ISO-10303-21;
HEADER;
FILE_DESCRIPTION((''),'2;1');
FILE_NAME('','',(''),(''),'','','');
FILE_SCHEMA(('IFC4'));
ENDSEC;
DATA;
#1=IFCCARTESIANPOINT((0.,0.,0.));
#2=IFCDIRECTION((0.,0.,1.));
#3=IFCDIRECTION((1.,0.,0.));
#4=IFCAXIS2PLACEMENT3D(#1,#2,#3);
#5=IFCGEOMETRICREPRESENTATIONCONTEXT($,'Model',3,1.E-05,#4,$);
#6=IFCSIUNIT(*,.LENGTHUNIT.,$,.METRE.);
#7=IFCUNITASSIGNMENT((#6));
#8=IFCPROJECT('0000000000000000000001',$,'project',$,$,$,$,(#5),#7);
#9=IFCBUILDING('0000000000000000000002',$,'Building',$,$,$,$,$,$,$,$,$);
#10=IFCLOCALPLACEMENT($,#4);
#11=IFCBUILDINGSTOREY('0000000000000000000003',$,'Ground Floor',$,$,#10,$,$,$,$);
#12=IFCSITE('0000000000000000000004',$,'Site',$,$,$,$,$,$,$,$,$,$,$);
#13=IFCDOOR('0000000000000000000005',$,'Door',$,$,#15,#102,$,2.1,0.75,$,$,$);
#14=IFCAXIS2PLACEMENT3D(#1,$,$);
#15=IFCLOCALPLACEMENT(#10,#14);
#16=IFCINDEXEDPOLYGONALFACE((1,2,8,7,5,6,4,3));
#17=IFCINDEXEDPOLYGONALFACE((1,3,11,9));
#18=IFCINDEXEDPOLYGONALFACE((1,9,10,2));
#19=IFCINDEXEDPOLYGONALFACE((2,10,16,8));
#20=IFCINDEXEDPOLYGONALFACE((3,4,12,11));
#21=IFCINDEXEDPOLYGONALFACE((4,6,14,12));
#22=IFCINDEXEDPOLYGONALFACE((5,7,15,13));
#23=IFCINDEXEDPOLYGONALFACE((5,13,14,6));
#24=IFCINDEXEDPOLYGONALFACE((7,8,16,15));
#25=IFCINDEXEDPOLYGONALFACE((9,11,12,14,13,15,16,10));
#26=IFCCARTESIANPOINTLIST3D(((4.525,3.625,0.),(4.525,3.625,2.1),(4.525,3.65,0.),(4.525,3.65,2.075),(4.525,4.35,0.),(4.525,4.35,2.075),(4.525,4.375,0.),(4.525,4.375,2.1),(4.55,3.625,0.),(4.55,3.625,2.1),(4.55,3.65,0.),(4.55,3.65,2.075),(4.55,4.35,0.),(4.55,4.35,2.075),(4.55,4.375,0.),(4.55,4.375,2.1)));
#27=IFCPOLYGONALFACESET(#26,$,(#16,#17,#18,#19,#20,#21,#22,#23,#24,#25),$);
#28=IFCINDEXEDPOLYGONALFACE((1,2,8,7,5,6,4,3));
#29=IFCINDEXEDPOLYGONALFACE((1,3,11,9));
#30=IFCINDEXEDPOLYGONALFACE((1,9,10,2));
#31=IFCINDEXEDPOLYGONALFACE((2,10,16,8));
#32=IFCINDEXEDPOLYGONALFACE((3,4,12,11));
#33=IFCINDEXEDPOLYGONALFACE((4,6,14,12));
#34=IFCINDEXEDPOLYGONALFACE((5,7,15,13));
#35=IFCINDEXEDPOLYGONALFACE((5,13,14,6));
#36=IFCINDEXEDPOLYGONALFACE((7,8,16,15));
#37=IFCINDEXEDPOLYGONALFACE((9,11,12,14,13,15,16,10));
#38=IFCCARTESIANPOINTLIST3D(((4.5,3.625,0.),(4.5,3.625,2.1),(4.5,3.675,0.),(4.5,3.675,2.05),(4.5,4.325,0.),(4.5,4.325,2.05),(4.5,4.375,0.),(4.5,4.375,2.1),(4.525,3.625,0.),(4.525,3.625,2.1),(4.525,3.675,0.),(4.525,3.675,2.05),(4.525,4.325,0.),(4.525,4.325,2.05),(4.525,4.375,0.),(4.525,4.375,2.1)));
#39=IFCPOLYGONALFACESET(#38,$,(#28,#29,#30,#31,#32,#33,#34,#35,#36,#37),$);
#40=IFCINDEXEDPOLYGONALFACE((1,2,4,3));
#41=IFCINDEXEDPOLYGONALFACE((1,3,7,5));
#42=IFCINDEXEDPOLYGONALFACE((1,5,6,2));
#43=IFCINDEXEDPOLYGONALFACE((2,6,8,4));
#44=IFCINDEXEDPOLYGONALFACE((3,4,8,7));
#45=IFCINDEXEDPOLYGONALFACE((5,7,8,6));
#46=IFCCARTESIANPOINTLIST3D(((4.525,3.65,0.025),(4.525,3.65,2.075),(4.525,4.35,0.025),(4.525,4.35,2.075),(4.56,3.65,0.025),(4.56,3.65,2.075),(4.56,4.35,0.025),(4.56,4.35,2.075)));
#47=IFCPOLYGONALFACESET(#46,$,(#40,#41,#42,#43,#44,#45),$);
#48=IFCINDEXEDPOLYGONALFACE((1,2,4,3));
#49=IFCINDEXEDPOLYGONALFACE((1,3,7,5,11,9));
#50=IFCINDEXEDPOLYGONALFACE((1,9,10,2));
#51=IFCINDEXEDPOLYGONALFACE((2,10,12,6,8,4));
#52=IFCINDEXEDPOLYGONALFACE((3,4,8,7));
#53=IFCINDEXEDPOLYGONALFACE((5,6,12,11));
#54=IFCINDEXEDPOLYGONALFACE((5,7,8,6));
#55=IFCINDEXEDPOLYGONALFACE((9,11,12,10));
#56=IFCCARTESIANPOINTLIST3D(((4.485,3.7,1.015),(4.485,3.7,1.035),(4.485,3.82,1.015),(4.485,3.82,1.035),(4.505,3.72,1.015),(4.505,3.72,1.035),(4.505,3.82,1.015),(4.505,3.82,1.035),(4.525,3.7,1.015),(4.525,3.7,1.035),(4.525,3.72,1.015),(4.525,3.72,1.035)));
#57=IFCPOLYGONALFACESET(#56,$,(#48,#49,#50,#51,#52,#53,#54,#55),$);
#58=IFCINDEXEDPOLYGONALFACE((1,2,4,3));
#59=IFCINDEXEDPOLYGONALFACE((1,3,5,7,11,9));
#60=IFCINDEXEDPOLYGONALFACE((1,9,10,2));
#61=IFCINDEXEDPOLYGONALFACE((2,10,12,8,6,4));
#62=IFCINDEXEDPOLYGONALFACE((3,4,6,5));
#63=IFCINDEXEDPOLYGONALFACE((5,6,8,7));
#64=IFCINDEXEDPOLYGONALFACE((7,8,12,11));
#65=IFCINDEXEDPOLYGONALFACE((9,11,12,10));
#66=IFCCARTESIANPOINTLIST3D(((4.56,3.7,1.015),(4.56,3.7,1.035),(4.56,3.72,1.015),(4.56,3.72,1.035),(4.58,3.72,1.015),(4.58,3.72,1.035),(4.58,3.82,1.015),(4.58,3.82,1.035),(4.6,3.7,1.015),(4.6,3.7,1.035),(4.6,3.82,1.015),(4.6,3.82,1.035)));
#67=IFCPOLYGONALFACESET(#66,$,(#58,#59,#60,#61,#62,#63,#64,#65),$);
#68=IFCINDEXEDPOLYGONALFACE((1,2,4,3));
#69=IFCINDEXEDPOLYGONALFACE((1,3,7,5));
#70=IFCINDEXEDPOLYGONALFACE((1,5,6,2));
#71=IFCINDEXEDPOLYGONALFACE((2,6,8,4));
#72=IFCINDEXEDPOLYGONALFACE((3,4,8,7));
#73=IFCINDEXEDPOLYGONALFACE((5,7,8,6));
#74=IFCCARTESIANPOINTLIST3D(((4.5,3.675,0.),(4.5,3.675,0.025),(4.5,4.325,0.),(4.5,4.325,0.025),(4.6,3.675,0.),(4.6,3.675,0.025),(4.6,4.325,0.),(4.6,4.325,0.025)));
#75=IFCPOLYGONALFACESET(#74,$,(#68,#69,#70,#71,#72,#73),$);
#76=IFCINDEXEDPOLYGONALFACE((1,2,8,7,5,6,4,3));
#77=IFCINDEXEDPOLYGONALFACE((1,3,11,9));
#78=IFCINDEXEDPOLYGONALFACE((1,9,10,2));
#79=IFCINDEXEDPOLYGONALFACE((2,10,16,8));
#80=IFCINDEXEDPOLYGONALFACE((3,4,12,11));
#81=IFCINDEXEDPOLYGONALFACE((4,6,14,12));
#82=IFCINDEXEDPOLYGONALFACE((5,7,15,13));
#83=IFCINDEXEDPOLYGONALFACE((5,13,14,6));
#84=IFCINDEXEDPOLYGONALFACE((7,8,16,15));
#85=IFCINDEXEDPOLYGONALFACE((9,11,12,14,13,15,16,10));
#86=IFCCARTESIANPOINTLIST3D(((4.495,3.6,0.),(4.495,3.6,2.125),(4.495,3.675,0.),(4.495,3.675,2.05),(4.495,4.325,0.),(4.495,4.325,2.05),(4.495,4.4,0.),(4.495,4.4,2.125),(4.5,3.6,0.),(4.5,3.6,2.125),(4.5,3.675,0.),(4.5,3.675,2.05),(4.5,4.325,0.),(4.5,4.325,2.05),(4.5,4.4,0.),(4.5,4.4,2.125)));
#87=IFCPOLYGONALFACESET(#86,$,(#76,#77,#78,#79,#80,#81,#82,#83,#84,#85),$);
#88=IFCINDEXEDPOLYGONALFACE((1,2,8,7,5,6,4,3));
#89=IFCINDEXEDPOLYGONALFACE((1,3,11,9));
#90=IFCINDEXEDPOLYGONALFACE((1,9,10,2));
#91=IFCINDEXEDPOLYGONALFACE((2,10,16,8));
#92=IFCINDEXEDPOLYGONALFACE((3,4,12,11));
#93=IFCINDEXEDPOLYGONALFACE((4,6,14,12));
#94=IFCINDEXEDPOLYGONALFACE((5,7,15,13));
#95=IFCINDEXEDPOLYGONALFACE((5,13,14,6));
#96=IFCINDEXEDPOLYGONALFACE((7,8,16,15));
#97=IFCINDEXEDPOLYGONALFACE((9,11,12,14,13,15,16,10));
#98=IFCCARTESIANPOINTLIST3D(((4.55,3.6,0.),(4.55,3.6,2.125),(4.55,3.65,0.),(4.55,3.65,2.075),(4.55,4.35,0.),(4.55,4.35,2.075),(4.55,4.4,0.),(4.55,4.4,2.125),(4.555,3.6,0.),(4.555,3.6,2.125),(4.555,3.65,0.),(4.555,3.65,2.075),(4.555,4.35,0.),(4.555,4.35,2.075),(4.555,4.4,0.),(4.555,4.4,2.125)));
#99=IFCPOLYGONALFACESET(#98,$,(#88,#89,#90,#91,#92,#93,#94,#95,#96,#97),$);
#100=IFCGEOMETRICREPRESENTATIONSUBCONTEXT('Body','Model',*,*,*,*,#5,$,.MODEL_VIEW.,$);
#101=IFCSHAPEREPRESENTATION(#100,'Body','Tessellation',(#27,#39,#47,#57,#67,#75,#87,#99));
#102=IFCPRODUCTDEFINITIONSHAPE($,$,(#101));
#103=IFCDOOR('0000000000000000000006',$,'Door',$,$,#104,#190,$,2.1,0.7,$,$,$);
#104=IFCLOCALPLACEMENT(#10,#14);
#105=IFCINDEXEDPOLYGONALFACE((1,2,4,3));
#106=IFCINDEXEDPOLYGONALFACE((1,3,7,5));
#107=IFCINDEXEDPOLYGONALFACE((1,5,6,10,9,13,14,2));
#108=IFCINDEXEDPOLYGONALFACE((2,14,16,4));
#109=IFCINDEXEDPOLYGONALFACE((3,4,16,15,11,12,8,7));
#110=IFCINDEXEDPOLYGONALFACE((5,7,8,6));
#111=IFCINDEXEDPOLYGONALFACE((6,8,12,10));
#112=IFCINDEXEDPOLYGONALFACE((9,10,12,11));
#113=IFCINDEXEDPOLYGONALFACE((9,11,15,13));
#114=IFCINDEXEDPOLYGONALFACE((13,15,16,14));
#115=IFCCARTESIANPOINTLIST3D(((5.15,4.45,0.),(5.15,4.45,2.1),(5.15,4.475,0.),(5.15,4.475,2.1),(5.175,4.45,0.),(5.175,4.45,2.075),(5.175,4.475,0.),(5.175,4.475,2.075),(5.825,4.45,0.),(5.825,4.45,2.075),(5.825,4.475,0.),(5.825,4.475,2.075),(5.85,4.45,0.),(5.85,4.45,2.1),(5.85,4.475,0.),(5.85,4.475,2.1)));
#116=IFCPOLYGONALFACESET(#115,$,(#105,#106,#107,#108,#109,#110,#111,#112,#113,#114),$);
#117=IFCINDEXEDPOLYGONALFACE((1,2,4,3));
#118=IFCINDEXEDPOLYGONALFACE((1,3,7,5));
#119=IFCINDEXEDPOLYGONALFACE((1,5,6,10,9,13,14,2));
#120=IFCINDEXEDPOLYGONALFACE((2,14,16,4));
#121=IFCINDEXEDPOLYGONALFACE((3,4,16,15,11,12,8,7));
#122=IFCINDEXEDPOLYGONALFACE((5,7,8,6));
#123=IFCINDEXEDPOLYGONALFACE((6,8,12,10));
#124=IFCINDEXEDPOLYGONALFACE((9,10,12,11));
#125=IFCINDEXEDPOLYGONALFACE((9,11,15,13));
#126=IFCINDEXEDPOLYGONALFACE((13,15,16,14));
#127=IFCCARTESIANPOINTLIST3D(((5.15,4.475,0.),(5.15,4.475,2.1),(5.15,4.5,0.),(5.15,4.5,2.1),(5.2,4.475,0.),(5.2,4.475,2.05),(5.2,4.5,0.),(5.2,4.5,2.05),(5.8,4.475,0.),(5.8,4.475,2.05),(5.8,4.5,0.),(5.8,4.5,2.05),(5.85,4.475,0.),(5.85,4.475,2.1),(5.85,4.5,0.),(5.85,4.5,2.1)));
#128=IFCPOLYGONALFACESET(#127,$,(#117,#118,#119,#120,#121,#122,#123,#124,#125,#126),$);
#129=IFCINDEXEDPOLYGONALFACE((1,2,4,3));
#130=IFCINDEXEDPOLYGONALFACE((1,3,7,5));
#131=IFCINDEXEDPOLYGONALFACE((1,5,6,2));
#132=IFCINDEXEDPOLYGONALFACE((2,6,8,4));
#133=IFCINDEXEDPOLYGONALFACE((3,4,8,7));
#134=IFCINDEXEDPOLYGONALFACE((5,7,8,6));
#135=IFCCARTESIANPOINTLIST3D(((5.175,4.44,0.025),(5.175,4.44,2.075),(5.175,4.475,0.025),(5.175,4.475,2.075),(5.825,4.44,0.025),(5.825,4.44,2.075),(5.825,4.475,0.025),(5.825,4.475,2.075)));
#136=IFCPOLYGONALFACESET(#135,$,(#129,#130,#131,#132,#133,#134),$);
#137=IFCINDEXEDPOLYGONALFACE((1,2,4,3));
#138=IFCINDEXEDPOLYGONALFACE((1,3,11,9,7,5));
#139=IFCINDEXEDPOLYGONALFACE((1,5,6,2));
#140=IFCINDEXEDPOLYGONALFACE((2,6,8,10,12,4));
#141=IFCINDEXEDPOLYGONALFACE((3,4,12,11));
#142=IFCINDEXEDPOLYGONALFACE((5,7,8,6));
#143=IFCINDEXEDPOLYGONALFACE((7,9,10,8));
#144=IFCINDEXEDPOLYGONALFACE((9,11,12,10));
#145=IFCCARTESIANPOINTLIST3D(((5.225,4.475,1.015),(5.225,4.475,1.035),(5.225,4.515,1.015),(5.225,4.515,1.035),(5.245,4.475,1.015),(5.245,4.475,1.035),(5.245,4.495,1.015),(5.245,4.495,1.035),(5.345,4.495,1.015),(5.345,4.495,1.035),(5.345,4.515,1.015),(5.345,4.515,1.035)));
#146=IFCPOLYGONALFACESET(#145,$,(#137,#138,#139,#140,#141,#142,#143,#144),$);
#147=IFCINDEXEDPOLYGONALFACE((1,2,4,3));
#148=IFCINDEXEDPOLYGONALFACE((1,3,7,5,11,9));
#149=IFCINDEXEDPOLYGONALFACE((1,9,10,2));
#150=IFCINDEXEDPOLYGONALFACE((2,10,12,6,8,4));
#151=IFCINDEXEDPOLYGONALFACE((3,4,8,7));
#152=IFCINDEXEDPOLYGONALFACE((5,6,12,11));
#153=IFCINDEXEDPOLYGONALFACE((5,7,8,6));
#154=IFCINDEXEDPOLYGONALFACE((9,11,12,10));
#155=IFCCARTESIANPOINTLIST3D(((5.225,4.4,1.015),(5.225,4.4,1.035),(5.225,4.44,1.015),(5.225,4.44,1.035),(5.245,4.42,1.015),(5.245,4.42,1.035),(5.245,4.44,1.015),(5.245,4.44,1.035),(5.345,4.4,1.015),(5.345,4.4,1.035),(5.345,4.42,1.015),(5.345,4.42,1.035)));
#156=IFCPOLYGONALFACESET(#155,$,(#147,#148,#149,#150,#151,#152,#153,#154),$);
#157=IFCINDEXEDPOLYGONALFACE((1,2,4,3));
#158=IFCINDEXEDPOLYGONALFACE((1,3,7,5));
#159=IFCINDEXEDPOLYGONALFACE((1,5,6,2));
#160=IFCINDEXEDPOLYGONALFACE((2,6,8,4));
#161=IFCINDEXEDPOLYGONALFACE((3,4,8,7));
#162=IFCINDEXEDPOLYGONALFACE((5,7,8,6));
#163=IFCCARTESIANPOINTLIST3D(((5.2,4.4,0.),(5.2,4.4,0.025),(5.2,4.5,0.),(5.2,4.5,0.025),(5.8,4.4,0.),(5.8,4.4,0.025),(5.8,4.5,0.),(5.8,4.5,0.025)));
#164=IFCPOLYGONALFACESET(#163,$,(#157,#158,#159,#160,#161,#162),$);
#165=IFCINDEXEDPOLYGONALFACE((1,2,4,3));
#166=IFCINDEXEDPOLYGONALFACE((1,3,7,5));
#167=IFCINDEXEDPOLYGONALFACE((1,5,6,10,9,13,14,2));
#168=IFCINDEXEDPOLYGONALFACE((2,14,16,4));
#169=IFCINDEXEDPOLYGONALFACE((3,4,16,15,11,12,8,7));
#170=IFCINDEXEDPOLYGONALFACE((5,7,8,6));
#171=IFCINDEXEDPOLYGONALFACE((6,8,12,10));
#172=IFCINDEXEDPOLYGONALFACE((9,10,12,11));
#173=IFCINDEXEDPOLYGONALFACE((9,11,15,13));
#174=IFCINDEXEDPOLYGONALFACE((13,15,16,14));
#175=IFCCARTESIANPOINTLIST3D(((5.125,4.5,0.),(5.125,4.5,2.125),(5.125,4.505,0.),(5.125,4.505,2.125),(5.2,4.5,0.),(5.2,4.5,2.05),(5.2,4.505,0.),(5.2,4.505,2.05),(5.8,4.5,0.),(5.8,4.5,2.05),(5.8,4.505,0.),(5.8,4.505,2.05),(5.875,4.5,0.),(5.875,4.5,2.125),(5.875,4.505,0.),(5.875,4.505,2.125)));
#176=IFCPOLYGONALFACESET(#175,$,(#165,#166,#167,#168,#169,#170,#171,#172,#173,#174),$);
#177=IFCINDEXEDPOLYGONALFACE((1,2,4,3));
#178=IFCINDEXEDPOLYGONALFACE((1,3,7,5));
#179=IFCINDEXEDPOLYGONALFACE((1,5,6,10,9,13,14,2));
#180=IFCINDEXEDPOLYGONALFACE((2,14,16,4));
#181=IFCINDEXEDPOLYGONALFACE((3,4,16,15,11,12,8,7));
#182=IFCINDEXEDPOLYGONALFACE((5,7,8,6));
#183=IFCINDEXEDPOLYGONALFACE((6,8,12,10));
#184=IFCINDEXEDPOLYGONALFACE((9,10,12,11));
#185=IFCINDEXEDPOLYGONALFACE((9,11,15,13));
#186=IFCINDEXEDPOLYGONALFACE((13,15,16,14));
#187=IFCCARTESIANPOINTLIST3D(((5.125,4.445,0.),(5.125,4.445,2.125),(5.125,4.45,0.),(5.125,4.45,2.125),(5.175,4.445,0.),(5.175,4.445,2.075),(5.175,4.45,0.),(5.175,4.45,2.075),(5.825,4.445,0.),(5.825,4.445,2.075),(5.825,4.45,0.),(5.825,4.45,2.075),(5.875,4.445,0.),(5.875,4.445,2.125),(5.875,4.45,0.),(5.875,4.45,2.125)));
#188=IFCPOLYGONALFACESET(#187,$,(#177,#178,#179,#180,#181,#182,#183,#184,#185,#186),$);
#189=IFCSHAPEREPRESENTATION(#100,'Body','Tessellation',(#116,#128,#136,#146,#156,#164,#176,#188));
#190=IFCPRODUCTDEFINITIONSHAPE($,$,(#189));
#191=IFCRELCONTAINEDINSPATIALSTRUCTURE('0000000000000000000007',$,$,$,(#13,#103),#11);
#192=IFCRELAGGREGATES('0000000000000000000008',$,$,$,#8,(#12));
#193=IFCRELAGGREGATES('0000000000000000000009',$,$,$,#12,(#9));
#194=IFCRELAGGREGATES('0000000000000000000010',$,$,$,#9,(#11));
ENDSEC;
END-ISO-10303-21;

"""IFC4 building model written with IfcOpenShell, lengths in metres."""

from ifc_helpers import new_model, si_unit, frame, origin_with_axes, place, context, subcontext, project, spatial, line, indexed_curve, outline, extrude, element, save


model = new_model("IFC4")

# Units and contexts
model_context = context("Model", 3, precision=1e-05, world=origin_with_axes())
body_context = subcontext(model_context, "Body", "Model", "MODEL_VIEW")
ifc_project = project(units=[si_unit("LENGTHUNIT", "METRE")], contexts=[model_context])

# Site, building, storey
site = spatial("IfcSite", under=ifc_project, Name="Site")
building = spatial("IfcBuilding", under=site, Name="Building")
storey_placement = place(None, origin_with_axes())
storey = spatial("IfcBuildingStorey", under=building, at=storey_placement, Name="Ground Floor")

# Doors
door_1_placement = place(storey_placement, frame((4.5, 4.375, 0.0), z_axis=(0.0, 0.0, 1.0), x_axis=(0.0, -1.0, 0.0)))
element("IfcDoor", 1, at=door_1_placement, inside=storey, Name="Door", OverallHeight=2.1, OverallWidth=0.75, context=body_context, shape_type="SweptSolid", body=[
    extrude(outline(indexed_curve([(0.0, 0.0), (0.0, 2.1), (0.75, 2.1), (0.75, 0.0), (0.725, 0.0), (0.725, 2.075), (0.025, 2.075), (0.025, 0.0)], segments=[line(1, 2, 3, 4, 5, 6, 7, 8, 1)])), frame((0.0, 0.025, 0.0), z_axis=(0.0, -1.0, 0.0), x_axis=(1.0, 0.0, 0.0)), (0.0, 0.0, -1.0), 0.025),
    extrude(outline(indexed_curve([(0.0, 0.0), (0.0, 2.1), (0.75, 2.1), (0.75, 0.0), (0.7, 0.0), (0.7, 2.05), (0.05, 2.05), (0.05, 0.0)], segments=[line(1, 2, 3, 4, 5, 6, 7, 8, 1)])), frame((0.0, 0.0, 0.0), z_axis=(0.0, -1.0, 0.0), x_axis=(1.0, 0.0, 0.0)), (0.0, 0.0, -1.0), 0.025),
    extrude(outline(indexed_curve([(0.0, 0.0), (0.7, 0.0), (0.7, 0.035), (0.0, 0.035)], segments=[line(1, 2, 3, 4, 1)])), frame((0.025, 0.025, 0.025), z_axis=(0.0, 0.0, 1.0), x_axis=(1.0, 0.0, 0.0)), (0.0, 0.0, 1.0), 2.05),
    extrude(outline(indexed_curve([(0.0, 0.0), (0.0, -0.04), (-0.12, -0.04), (-0.12, -0.02), (-0.02, -0.02), (-0.02, 0.0)], segments=[line(1, 2, 3, 4, 5, 6, 1)])), frame((0.675, 0.025, 1.015), z_axis=(0.0, 0.0, 1.0), x_axis=(1.0, 0.0, 0.0)), (0.0, 0.0, 1.0), 0.02),
    extrude(outline(indexed_curve([(0.0, 0.0), (0.0, 0.04), (-0.12, 0.04), (-0.12, 0.02), (-0.02, 0.02), (-0.02, 0.0)], segments=[line(1, 2, 3, 4, 5, 6, 1)])), frame((0.675, 0.06, 1.015), z_axis=(0.0, 0.0, 1.0), x_axis=(1.0, 0.0, 0.0)), (0.0, 0.0, 1.0), 0.02),
    extrude(outline(indexed_curve([(0.0, 0.0), (0.65, 0.0), (0.65, 0.1), (0.0, 0.1)], segments=[line(1, 2, 3, 4, 1)])), frame((0.05, 0.0, 0.0), z_axis=(0.0, 0.0, 1.0), x_axis=(1.0, 0.0, 0.0)), (0.0, 0.0, 1.0), 0.025),
    extrude(outline(indexed_curve([(0.0, 0.0), (0.0, 2.125), (0.8, 2.125), (0.8, 0.0), (0.725, 0.0), (0.725, 2.05), (0.075, 2.05), (0.075, 0.0)], segments=[line(1, 2, 3, 4, 5, 6, 7, 8, 1)])), frame((-0.025, -0.005, 0.0), z_axis=(0.0, -1.0, 0.0), x_axis=(1.0, 0.0, 0.0)), (0.0, 0.0, -1.0), 0.005),
    extrude(outline(indexed_curve([(0.0, 0.0), (0.0, 2.125), (0.8, 2.125), (0.8, 0.0), (0.75, 0.0), (0.75, 2.075), (0.05, 2.075), (0.05, 0.0)], segments=[line(1, 2, 3, 4, 5, 6, 7, 8, 1)])), frame((-0.025, 0.05, 0.0), z_axis=(0.0, -1.0, 0.0), x_axis=(1.0, 0.0, 0.0)), (0.0, 0.0, -1.0), 0.005),
])
door_2_placement = place(storey_placement, frame((5.85, 4.5, 0.0), z_axis=(0.0, 0.0, 1.0), x_axis=(-1.0, 0.0, 0.0)))
element("IfcDoor", 2, at=door_2_placement, inside=storey, Name="Door", OverallHeight=2.1, OverallWidth=0.7, context=body_context, shape_type="SweptSolid", body=[
    extrude(outline(indexed_curve([(0.0, 0.0), (0.0, 2.1), (0.7, 2.1), (0.7, 0.0), (0.675, 0.0), (0.675, 2.075), (0.025, 2.075), (0.025, 0.0)], segments=[line(1, 2, 3, 4, 5, 6, 7, 8, 1)])), frame((0.0, 0.025, 0.0), z_axis=(0.0, -1.0, 0.0), x_axis=(1.0, 0.0, 0.0)), (0.0, 0.0, -1.0), 0.025),
    extrude(outline(indexed_curve([(0.0, 0.0), (0.0, 2.1), (0.7, 2.1), (0.7, 0.0), (0.65, 0.0), (0.65, 2.05), (0.05, 2.05), (0.05, 0.0)], segments=[line(1, 2, 3, 4, 5, 6, 7, 8, 1)])), frame((0.0, 0.0, 0.0), z_axis=(0.0, -1.0, 0.0), x_axis=(1.0, 0.0, 0.0)), (0.0, 0.0, -1.0), 0.025),
    extrude(outline(indexed_curve([(0.0, 0.0), (0.65, 0.0), (0.65, 0.035), (0.0, 0.035)], segments=[line(1, 2, 3, 4, 1)])), frame((0.025, 0.025, 0.025), z_axis=(0.0, 0.0, 1.0), x_axis=(1.0, 0.0, 0.0)), (0.0, 0.0, 1.0), 2.05),
    extrude(outline(indexed_curve([(0.0, 0.0), (0.0, -0.04), (-0.12, -0.04), (-0.12, -0.02), (-0.02, -0.02), (-0.02, 0.0)], segments=[line(1, 2, 3, 4, 5, 6, 1)])), frame((0.625, 0.025, 1.015), z_axis=(0.0, 0.0, 1.0), x_axis=(1.0, 0.0, 0.0)), (0.0, 0.0, 1.0), 0.02),
    extrude(outline(indexed_curve([(0.0, 0.0), (0.0, 0.04), (-0.12, 0.04), (-0.12, 0.02), (-0.02, 0.02), (-0.02, 0.0)], segments=[line(1, 2, 3, 4, 5, 6, 1)])), frame((0.625, 0.06, 1.015), z_axis=(0.0, 0.0, 1.0), x_axis=(1.0, 0.0, 0.0)), (0.0, 0.0, 1.0), 0.02),
    extrude(outline(indexed_curve([(0.0, 0.0), (0.6, 0.0), (0.6, 0.1), (0.0, 0.1)], segments=[line(1, 2, 3, 4, 1)])), frame((0.05, 0.0, 0.0), z_axis=(0.0, 0.0, 1.0), x_axis=(1.0, 0.0, 0.0)), (0.0, 0.0, 1.0), 0.025),
    extrude(outline(indexed_curve([(0.0, 0.0), (0.0, 2.125), (0.75, 2.125), (0.75, 0.0), (0.675, 0.0), (0.675, 2.05), (0.075, 2.05), (0.075, 0.0)], segments=[line(1, 2, 3, 4, 5, 6, 7, 8, 1)])), frame((-0.025, -0.005, 0.0), z_axis=(0.0, -1.0, 0.0), x_axis=(1.0, 0.0, 0.0)), (0.0, 0.0, -1.0), 0.005),
    extrude(outline(indexed_curve([(0.0, 0.0), (0.0, 2.125), (0.75, 2.125), (0.75, 0.0), (0.7, 0.0), (0.7, 2.075), (0.05, 2.075), (0.05, 0.0)], segments=[line(1, 2, 3, 4, 5, 6, 7, 8, 1)])), frame((-0.025, 0.05, 0.0), z_axis=(0.0, -1.0, 0.0), x_axis=(1.0, 0.0, 0.0)), (0.0, 0.0, -1.0), 0.005),
])

save(model, "model.ifc")
